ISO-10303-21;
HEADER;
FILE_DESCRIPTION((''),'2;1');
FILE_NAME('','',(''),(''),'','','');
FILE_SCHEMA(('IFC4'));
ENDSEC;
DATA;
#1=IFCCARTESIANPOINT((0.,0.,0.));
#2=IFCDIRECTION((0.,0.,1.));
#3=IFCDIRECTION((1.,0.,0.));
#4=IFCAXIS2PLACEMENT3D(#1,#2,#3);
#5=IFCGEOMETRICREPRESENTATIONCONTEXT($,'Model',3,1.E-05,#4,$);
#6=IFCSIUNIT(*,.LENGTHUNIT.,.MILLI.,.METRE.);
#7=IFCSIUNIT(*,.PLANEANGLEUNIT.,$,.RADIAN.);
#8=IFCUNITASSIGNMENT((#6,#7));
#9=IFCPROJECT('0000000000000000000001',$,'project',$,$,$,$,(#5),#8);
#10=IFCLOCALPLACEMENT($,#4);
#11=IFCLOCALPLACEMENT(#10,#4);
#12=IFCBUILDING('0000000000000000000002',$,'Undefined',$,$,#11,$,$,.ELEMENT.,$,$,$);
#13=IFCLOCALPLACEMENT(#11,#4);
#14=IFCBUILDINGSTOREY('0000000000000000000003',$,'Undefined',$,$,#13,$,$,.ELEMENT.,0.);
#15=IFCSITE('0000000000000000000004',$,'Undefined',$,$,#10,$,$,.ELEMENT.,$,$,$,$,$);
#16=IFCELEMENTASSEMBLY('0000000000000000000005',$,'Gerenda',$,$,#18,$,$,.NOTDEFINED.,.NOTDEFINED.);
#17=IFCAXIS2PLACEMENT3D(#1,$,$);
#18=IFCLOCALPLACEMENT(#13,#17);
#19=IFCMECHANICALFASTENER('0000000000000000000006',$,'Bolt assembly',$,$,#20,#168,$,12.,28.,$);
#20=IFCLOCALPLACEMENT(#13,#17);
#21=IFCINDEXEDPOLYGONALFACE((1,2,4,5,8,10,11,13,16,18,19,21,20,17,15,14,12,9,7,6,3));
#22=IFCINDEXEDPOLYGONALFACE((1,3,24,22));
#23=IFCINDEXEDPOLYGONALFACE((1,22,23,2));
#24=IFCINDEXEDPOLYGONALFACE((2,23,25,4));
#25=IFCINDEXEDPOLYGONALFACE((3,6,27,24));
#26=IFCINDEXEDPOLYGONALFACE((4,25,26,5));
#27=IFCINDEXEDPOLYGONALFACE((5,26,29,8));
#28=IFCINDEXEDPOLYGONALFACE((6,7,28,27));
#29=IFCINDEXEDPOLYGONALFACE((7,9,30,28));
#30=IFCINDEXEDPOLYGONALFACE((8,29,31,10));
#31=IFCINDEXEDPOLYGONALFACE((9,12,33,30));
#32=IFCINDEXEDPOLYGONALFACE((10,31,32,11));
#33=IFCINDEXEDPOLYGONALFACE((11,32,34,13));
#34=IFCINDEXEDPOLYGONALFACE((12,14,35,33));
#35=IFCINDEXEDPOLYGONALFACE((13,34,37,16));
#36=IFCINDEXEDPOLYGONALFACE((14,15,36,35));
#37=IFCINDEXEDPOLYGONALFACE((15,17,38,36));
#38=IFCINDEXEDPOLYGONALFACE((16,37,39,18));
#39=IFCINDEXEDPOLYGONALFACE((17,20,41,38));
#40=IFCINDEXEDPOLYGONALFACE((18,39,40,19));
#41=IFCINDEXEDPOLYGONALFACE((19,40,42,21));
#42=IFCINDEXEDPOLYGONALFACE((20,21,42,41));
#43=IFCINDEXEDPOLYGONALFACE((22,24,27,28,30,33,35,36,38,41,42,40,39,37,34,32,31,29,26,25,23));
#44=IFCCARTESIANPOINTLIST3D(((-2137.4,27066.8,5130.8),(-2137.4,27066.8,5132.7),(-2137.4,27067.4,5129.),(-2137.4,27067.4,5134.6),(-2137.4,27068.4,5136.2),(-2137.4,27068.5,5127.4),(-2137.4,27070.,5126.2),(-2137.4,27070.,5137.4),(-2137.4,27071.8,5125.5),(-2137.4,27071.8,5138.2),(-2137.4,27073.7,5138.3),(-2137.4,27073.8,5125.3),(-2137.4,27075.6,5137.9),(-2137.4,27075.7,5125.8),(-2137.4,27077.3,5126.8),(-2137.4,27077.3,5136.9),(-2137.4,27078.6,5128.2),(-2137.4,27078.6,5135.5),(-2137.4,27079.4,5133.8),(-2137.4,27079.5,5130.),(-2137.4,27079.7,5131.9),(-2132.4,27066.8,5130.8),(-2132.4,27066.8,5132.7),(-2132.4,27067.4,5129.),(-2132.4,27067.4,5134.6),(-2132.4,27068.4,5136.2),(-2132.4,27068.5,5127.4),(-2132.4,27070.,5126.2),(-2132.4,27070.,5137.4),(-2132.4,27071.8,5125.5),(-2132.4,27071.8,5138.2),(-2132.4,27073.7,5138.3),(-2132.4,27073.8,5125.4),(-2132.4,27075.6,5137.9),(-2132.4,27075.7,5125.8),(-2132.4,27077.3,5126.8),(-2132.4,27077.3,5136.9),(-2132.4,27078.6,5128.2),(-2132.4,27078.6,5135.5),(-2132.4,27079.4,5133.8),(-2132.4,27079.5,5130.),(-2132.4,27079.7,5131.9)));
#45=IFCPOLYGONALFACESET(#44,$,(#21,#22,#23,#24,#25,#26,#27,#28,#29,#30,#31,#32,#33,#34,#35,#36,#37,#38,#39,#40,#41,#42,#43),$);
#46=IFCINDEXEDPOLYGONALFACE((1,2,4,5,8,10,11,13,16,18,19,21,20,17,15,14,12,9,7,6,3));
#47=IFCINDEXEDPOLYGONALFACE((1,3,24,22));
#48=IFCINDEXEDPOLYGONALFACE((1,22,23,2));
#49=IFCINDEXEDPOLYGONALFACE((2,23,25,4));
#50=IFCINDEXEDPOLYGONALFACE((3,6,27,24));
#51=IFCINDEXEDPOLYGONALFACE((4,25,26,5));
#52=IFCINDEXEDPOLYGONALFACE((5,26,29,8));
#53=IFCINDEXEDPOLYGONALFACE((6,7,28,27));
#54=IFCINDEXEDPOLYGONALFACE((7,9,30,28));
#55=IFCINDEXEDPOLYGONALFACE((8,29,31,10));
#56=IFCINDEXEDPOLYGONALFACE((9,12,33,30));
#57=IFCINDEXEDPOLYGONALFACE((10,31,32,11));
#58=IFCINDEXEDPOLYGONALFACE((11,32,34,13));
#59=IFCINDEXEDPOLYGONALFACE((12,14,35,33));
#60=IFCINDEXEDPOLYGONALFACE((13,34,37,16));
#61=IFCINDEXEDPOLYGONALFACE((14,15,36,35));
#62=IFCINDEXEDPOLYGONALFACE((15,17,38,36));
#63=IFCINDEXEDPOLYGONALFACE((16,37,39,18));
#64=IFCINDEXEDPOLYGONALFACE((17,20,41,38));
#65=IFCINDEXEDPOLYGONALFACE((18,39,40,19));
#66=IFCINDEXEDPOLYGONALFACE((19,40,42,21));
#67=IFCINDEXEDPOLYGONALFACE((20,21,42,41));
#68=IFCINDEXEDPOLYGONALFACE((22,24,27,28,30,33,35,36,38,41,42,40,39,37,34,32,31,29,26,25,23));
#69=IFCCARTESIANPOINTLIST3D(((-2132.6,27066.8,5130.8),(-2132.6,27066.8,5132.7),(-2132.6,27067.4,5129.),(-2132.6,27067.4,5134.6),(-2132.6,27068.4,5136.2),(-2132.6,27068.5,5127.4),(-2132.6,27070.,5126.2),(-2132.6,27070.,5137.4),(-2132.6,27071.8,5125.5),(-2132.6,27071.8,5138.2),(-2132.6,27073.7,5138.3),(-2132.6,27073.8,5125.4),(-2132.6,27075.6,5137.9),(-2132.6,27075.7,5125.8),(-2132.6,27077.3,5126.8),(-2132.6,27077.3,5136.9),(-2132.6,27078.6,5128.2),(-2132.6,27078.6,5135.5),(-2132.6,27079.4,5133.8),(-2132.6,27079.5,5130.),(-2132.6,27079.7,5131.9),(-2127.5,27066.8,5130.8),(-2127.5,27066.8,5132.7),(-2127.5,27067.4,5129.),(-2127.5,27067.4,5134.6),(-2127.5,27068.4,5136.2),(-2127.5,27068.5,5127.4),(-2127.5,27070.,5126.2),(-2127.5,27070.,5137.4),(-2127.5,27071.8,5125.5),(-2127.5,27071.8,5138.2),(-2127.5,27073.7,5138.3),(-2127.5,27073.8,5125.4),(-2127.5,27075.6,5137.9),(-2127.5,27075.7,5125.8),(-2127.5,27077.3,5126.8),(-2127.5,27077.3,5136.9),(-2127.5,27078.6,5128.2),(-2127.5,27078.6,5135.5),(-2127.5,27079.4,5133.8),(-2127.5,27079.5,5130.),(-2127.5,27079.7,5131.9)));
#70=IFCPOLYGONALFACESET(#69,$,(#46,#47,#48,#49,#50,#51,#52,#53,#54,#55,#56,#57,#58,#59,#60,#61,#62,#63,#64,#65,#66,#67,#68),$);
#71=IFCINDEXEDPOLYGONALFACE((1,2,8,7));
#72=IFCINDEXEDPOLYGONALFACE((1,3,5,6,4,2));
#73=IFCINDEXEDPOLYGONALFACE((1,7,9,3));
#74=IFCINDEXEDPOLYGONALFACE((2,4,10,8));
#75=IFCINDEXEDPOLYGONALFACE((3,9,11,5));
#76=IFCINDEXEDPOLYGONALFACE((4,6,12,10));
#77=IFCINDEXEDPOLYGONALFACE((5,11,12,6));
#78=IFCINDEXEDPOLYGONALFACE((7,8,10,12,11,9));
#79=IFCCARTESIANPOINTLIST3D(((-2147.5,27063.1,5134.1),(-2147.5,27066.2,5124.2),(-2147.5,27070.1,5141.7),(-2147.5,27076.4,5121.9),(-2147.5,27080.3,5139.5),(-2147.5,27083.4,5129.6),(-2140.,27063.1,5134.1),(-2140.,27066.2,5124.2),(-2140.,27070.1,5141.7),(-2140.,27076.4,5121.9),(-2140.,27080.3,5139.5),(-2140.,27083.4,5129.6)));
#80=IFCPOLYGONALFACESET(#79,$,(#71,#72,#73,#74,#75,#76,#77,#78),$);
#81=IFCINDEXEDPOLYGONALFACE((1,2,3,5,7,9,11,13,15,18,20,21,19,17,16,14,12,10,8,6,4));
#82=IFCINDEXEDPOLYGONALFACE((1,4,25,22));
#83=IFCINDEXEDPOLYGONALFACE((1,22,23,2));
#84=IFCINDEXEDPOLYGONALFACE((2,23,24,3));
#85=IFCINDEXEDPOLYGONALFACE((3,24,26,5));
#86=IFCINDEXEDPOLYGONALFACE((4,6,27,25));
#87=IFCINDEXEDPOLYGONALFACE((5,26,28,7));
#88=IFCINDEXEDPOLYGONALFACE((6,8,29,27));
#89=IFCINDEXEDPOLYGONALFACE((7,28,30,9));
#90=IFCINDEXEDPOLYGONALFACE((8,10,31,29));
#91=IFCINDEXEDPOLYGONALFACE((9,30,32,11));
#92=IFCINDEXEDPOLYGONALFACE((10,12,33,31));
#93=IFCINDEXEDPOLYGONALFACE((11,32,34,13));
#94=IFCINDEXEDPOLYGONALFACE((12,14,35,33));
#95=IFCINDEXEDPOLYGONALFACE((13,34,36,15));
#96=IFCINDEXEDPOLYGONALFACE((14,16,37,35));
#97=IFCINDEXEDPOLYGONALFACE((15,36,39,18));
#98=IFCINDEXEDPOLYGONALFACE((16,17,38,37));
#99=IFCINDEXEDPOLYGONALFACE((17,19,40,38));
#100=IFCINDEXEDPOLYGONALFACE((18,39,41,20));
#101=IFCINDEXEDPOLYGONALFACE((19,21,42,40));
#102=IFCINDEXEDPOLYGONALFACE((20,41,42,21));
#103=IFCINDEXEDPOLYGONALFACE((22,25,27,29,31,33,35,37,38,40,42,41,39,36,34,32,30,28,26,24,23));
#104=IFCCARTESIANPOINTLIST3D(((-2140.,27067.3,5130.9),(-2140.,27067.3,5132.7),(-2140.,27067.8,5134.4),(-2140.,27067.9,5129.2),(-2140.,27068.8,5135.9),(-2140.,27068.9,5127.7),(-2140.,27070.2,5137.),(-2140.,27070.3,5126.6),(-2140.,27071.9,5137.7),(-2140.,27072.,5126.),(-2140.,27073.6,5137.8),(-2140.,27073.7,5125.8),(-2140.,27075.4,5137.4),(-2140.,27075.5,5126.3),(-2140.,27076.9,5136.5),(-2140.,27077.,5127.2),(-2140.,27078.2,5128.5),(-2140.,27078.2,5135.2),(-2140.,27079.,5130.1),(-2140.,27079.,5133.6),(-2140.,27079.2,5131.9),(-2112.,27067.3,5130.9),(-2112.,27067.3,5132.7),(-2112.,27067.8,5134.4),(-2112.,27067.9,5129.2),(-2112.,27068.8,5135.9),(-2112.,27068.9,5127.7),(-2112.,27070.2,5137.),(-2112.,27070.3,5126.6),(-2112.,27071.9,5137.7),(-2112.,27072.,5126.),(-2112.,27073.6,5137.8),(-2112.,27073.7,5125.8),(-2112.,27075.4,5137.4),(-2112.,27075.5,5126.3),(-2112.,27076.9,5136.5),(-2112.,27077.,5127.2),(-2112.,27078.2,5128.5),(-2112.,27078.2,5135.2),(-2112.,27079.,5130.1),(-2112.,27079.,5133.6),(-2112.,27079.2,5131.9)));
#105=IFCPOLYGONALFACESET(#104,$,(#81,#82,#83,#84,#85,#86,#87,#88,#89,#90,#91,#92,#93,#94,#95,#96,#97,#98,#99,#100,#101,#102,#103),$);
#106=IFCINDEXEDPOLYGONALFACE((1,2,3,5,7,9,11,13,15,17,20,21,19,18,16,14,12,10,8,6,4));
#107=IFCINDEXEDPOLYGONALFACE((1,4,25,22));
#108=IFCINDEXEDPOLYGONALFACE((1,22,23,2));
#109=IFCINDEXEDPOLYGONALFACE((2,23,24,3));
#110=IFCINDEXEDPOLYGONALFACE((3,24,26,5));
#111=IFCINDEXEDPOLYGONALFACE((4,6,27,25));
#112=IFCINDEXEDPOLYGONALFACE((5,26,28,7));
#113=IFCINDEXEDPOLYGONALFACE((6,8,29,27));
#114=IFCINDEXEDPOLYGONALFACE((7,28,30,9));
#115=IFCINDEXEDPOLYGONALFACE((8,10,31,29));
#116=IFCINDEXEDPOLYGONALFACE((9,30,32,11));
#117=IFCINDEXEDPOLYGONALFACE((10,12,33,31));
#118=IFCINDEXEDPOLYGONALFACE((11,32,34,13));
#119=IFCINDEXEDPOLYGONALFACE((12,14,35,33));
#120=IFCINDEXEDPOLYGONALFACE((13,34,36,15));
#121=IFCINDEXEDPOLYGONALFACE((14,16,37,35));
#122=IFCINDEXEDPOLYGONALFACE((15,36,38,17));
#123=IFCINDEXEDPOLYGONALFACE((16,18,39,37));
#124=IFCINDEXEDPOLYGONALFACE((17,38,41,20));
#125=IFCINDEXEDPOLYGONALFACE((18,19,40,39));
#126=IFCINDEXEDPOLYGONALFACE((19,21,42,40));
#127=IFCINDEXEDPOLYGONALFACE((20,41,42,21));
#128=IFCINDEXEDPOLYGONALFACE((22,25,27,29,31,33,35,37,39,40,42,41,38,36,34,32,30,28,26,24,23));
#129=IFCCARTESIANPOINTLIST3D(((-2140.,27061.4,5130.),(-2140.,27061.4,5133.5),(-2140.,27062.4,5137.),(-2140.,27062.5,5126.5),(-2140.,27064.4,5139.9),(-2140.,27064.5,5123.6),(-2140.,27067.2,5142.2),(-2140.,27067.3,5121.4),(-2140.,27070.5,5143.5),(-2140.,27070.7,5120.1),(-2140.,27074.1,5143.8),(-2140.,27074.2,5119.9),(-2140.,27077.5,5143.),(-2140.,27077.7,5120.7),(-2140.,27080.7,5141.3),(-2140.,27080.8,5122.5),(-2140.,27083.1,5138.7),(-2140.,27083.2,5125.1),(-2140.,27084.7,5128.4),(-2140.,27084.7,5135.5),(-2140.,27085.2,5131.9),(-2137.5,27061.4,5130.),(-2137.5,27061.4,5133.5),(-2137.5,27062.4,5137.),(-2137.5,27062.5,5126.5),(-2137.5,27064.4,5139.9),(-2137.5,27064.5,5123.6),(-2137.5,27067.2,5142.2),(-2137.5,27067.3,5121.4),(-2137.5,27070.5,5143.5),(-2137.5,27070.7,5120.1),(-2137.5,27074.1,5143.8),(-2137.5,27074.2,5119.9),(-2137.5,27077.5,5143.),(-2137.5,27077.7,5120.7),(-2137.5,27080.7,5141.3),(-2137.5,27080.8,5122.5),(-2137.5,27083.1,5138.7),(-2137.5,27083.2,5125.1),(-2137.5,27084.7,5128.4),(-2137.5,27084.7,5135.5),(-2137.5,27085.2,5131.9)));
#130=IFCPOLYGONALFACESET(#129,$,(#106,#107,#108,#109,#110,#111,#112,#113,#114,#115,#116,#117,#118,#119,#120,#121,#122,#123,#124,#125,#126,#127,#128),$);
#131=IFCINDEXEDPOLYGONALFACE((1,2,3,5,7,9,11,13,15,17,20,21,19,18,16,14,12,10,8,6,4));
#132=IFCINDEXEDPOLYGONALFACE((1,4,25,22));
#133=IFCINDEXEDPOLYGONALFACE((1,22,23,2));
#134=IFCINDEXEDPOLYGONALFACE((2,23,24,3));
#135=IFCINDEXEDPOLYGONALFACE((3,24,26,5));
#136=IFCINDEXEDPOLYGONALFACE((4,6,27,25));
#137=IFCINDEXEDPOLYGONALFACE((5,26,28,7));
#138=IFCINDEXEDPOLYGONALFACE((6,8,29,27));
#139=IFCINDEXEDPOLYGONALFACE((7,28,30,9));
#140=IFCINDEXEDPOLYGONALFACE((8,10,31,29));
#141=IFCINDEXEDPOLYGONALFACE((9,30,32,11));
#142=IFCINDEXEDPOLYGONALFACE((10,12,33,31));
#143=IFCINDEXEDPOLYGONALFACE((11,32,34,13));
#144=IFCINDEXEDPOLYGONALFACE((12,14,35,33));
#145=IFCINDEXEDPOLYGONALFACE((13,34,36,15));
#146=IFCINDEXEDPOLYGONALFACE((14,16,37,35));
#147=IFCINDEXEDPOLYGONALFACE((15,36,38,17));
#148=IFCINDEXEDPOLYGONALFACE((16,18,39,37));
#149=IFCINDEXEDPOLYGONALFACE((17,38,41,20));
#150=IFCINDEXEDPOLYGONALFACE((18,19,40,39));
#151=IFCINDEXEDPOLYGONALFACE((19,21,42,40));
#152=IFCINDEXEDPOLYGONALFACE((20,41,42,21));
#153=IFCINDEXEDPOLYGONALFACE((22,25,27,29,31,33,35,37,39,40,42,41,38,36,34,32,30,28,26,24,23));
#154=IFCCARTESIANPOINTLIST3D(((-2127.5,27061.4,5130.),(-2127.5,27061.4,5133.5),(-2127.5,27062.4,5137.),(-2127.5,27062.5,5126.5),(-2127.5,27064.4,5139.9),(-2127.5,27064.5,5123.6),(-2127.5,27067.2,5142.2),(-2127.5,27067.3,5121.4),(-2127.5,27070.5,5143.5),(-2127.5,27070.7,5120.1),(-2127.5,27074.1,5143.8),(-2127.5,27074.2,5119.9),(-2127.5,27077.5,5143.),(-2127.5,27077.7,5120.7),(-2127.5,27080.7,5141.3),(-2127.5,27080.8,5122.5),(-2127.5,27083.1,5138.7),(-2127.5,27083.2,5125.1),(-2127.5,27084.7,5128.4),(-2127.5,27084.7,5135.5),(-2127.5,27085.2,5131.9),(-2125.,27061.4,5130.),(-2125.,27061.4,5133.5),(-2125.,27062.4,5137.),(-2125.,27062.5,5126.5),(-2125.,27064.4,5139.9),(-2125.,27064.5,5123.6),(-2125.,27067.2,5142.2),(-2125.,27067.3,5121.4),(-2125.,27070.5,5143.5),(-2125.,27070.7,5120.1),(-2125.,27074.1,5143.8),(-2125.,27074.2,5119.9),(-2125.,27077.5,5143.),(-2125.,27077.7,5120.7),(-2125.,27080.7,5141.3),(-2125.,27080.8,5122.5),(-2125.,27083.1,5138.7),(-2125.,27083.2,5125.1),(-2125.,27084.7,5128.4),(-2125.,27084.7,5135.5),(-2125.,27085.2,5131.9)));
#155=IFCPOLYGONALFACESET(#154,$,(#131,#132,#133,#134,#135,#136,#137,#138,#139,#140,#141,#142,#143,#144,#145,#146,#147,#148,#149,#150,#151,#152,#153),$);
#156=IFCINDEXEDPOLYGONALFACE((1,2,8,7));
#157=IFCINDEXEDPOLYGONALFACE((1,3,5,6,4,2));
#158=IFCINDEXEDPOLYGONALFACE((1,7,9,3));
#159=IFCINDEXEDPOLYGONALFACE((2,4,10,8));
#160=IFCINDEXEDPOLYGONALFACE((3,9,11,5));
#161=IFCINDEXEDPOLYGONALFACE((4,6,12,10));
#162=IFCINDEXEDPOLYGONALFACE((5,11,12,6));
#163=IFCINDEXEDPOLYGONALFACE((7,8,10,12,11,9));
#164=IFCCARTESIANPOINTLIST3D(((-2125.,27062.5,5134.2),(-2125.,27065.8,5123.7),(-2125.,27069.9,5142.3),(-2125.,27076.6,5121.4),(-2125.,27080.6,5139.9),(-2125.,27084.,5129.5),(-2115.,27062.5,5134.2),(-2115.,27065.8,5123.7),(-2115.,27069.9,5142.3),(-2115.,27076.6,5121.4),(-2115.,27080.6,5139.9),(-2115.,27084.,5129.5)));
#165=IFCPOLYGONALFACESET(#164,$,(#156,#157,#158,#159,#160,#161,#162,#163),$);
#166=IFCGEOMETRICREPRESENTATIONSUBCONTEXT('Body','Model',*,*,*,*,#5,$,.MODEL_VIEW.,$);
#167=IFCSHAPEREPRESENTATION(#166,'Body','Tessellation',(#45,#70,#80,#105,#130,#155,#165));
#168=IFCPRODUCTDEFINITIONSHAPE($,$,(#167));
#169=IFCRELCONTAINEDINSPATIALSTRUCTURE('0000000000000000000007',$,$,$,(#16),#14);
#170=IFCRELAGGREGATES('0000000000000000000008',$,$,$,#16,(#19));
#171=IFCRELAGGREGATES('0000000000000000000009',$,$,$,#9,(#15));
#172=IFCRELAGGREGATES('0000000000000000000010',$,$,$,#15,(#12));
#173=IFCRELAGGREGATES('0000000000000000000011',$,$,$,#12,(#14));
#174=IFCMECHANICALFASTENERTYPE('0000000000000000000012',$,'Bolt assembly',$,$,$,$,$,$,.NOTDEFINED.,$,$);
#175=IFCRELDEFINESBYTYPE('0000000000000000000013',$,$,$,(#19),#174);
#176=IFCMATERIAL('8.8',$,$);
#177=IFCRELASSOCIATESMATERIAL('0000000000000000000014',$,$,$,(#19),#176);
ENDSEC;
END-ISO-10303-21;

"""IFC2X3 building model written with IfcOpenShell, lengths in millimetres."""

from ifc_helpers import new_model, si_unit, frame, origin_with_axes, origin_2d_with_axis, place, context, subcontext, project, spatial, polyline, circle, outline, extrude, source, transform, mapped, material, type_object, element, aggregate, save


model = new_model("IFC2X3")

# Units and contexts
model_context = context("Model", 3, precision=1e-05, world=origin_with_axes())
body_context = subcontext(model_context, "Body", "Model", "MODEL_VIEW")
ifc_project = project(units=[si_unit("LENGTHUNIT", "METRE", prefix="MILLI"), si_unit("PLANEANGLEUNIT", "RADIAN")], contexts=[model_context])

# Site, building, storey
site_placement = place(None, origin_with_axes())
site = spatial("IfcSite", under=ifc_project, at=site_placement, Name="Undefined", CompositionType="ELEMENT")
building_placement = place(site_placement, origin_with_axes())
building = spatial("IfcBuilding", under=site, at=building_placement, Name="Undefined", CompositionType="ELEMENT")
storey_placement = place(building_placement, origin_with_axes())
storey = spatial("IfcBuildingStorey", under=building, at=storey_placement, Name="Undefined", CompositionType="ELEMENT", Elevation=0.0)

# Element assembly
assembly_1_placement = place(storey_placement, origin_with_axes())
assembly_1 = element("IfcElementAssembly", 1, at=assembly_1_placement, inside=storey, Name="Gerenda", AssemblyPlace="NOTDEFINED", PredefinedType="NOTDEFINED")

# Mechanical fastener
ifc_material_1 = material(Name="8.8")
mechanical_fastener_type = type_object("IfcMechanicalFastenerType", Name="Bolt assembly")
shared_shape_1 = source(origin_with_axes(), body_context, "Body", "SweptSolid", [
    extrude(circle(Radius=6.5, at=origin_2d_with_axis()), frame((0.0, -7.4, 0.0), z_axis=(0.0, 1.0, 0.0), x_axis=(1.0, 0.0, 0.0)), (0.0, 0.0, 1.0), 5.0),
    extrude(circle(Radius=6.5, at=origin_2d_with_axis()), frame((0.0, -2.6, 0.0), z_axis=(0.0, 1.0, 0.0), x_axis=(1.0, 0.0, 0.0)), (0.0, 0.0, 1.0), 5.1),
    extrude(outline(polyline([(9.0, -5.2), (9.0, 5.2), (0.0, 10.4), (-9.0, 5.2), (-9.0, -5.2), (0.0, -10.4), (9.0, -5.2)])), frame((0.0, -17.5, 0.0), z_axis=(0.0, 1.0, 0.0), x_axis=(1.0, 0.0, 0.0)), (0.0, 0.0, 1.0), 7.5),
    extrude(circle(Radius=6.0, at=origin_2d_with_axis()), frame((0.0, -10.0, 0.0), z_axis=(0.0, 1.0, 0.0), x_axis=(1.0, 0.0, 0.0)), (0.0, 0.0, 1.0), 28.0),
    extrude(circle(Radius=12.0, at=origin_2d_with_axis()), frame((0.0, -10.0, 0.0), z_axis=(0.0, 1.0, 0.0), x_axis=(1.0, 0.0, 0.0)), (0.0, 0.0, 1.0), 2.5),
    extrude(circle(Radius=12.0, at=origin_2d_with_axis()), frame((0.0, 2.5, 0.0), z_axis=(0.0, 1.0, 0.0), x_axis=(1.0, 0.0, 0.0)), (0.0, 0.0, 1.0), 2.5),
    extrude(outline(polyline([(9.5, -5.5), (9.5, 5.5), (0.0, 11.0), (-9.5, 5.5), (-9.5, -5.5), (0.0, -11.0), (9.5, -5.5)])), frame((0.0, 5.0, 0.0), z_axis=(0.0, 1.0, 0.0), x_axis=(1.0, 0.0, 0.0)), (0.0, 0.0, 1.0), 10.0),
])
mechanical_fastener_1_placement = place(assembly_1_placement, frame((-2130.0, 27073.2, 5131.8), z_axis=(-0.000003, 0.674627, 0.738159), x_axis=(-0.000003, -0.738159, 0.674627)))
mechanical_fastener_1 = element("IfcMechanicalFastener", 2, at=mechanical_fastener_1_placement, type_object=mechanical_fastener_type, material=ifc_material_1, Name="Bolt assembly", NominalDiameter=12.0, NominalLength=28.0, context=body_context, shape_type="MappedRepresentation", body=[
    mapped(shared_shape_1, transform((0.0, 0.0, 0.0))),
])
aggregate(assembly_1, [mechanical_fastener_1])

save(model, "model.ifc")
